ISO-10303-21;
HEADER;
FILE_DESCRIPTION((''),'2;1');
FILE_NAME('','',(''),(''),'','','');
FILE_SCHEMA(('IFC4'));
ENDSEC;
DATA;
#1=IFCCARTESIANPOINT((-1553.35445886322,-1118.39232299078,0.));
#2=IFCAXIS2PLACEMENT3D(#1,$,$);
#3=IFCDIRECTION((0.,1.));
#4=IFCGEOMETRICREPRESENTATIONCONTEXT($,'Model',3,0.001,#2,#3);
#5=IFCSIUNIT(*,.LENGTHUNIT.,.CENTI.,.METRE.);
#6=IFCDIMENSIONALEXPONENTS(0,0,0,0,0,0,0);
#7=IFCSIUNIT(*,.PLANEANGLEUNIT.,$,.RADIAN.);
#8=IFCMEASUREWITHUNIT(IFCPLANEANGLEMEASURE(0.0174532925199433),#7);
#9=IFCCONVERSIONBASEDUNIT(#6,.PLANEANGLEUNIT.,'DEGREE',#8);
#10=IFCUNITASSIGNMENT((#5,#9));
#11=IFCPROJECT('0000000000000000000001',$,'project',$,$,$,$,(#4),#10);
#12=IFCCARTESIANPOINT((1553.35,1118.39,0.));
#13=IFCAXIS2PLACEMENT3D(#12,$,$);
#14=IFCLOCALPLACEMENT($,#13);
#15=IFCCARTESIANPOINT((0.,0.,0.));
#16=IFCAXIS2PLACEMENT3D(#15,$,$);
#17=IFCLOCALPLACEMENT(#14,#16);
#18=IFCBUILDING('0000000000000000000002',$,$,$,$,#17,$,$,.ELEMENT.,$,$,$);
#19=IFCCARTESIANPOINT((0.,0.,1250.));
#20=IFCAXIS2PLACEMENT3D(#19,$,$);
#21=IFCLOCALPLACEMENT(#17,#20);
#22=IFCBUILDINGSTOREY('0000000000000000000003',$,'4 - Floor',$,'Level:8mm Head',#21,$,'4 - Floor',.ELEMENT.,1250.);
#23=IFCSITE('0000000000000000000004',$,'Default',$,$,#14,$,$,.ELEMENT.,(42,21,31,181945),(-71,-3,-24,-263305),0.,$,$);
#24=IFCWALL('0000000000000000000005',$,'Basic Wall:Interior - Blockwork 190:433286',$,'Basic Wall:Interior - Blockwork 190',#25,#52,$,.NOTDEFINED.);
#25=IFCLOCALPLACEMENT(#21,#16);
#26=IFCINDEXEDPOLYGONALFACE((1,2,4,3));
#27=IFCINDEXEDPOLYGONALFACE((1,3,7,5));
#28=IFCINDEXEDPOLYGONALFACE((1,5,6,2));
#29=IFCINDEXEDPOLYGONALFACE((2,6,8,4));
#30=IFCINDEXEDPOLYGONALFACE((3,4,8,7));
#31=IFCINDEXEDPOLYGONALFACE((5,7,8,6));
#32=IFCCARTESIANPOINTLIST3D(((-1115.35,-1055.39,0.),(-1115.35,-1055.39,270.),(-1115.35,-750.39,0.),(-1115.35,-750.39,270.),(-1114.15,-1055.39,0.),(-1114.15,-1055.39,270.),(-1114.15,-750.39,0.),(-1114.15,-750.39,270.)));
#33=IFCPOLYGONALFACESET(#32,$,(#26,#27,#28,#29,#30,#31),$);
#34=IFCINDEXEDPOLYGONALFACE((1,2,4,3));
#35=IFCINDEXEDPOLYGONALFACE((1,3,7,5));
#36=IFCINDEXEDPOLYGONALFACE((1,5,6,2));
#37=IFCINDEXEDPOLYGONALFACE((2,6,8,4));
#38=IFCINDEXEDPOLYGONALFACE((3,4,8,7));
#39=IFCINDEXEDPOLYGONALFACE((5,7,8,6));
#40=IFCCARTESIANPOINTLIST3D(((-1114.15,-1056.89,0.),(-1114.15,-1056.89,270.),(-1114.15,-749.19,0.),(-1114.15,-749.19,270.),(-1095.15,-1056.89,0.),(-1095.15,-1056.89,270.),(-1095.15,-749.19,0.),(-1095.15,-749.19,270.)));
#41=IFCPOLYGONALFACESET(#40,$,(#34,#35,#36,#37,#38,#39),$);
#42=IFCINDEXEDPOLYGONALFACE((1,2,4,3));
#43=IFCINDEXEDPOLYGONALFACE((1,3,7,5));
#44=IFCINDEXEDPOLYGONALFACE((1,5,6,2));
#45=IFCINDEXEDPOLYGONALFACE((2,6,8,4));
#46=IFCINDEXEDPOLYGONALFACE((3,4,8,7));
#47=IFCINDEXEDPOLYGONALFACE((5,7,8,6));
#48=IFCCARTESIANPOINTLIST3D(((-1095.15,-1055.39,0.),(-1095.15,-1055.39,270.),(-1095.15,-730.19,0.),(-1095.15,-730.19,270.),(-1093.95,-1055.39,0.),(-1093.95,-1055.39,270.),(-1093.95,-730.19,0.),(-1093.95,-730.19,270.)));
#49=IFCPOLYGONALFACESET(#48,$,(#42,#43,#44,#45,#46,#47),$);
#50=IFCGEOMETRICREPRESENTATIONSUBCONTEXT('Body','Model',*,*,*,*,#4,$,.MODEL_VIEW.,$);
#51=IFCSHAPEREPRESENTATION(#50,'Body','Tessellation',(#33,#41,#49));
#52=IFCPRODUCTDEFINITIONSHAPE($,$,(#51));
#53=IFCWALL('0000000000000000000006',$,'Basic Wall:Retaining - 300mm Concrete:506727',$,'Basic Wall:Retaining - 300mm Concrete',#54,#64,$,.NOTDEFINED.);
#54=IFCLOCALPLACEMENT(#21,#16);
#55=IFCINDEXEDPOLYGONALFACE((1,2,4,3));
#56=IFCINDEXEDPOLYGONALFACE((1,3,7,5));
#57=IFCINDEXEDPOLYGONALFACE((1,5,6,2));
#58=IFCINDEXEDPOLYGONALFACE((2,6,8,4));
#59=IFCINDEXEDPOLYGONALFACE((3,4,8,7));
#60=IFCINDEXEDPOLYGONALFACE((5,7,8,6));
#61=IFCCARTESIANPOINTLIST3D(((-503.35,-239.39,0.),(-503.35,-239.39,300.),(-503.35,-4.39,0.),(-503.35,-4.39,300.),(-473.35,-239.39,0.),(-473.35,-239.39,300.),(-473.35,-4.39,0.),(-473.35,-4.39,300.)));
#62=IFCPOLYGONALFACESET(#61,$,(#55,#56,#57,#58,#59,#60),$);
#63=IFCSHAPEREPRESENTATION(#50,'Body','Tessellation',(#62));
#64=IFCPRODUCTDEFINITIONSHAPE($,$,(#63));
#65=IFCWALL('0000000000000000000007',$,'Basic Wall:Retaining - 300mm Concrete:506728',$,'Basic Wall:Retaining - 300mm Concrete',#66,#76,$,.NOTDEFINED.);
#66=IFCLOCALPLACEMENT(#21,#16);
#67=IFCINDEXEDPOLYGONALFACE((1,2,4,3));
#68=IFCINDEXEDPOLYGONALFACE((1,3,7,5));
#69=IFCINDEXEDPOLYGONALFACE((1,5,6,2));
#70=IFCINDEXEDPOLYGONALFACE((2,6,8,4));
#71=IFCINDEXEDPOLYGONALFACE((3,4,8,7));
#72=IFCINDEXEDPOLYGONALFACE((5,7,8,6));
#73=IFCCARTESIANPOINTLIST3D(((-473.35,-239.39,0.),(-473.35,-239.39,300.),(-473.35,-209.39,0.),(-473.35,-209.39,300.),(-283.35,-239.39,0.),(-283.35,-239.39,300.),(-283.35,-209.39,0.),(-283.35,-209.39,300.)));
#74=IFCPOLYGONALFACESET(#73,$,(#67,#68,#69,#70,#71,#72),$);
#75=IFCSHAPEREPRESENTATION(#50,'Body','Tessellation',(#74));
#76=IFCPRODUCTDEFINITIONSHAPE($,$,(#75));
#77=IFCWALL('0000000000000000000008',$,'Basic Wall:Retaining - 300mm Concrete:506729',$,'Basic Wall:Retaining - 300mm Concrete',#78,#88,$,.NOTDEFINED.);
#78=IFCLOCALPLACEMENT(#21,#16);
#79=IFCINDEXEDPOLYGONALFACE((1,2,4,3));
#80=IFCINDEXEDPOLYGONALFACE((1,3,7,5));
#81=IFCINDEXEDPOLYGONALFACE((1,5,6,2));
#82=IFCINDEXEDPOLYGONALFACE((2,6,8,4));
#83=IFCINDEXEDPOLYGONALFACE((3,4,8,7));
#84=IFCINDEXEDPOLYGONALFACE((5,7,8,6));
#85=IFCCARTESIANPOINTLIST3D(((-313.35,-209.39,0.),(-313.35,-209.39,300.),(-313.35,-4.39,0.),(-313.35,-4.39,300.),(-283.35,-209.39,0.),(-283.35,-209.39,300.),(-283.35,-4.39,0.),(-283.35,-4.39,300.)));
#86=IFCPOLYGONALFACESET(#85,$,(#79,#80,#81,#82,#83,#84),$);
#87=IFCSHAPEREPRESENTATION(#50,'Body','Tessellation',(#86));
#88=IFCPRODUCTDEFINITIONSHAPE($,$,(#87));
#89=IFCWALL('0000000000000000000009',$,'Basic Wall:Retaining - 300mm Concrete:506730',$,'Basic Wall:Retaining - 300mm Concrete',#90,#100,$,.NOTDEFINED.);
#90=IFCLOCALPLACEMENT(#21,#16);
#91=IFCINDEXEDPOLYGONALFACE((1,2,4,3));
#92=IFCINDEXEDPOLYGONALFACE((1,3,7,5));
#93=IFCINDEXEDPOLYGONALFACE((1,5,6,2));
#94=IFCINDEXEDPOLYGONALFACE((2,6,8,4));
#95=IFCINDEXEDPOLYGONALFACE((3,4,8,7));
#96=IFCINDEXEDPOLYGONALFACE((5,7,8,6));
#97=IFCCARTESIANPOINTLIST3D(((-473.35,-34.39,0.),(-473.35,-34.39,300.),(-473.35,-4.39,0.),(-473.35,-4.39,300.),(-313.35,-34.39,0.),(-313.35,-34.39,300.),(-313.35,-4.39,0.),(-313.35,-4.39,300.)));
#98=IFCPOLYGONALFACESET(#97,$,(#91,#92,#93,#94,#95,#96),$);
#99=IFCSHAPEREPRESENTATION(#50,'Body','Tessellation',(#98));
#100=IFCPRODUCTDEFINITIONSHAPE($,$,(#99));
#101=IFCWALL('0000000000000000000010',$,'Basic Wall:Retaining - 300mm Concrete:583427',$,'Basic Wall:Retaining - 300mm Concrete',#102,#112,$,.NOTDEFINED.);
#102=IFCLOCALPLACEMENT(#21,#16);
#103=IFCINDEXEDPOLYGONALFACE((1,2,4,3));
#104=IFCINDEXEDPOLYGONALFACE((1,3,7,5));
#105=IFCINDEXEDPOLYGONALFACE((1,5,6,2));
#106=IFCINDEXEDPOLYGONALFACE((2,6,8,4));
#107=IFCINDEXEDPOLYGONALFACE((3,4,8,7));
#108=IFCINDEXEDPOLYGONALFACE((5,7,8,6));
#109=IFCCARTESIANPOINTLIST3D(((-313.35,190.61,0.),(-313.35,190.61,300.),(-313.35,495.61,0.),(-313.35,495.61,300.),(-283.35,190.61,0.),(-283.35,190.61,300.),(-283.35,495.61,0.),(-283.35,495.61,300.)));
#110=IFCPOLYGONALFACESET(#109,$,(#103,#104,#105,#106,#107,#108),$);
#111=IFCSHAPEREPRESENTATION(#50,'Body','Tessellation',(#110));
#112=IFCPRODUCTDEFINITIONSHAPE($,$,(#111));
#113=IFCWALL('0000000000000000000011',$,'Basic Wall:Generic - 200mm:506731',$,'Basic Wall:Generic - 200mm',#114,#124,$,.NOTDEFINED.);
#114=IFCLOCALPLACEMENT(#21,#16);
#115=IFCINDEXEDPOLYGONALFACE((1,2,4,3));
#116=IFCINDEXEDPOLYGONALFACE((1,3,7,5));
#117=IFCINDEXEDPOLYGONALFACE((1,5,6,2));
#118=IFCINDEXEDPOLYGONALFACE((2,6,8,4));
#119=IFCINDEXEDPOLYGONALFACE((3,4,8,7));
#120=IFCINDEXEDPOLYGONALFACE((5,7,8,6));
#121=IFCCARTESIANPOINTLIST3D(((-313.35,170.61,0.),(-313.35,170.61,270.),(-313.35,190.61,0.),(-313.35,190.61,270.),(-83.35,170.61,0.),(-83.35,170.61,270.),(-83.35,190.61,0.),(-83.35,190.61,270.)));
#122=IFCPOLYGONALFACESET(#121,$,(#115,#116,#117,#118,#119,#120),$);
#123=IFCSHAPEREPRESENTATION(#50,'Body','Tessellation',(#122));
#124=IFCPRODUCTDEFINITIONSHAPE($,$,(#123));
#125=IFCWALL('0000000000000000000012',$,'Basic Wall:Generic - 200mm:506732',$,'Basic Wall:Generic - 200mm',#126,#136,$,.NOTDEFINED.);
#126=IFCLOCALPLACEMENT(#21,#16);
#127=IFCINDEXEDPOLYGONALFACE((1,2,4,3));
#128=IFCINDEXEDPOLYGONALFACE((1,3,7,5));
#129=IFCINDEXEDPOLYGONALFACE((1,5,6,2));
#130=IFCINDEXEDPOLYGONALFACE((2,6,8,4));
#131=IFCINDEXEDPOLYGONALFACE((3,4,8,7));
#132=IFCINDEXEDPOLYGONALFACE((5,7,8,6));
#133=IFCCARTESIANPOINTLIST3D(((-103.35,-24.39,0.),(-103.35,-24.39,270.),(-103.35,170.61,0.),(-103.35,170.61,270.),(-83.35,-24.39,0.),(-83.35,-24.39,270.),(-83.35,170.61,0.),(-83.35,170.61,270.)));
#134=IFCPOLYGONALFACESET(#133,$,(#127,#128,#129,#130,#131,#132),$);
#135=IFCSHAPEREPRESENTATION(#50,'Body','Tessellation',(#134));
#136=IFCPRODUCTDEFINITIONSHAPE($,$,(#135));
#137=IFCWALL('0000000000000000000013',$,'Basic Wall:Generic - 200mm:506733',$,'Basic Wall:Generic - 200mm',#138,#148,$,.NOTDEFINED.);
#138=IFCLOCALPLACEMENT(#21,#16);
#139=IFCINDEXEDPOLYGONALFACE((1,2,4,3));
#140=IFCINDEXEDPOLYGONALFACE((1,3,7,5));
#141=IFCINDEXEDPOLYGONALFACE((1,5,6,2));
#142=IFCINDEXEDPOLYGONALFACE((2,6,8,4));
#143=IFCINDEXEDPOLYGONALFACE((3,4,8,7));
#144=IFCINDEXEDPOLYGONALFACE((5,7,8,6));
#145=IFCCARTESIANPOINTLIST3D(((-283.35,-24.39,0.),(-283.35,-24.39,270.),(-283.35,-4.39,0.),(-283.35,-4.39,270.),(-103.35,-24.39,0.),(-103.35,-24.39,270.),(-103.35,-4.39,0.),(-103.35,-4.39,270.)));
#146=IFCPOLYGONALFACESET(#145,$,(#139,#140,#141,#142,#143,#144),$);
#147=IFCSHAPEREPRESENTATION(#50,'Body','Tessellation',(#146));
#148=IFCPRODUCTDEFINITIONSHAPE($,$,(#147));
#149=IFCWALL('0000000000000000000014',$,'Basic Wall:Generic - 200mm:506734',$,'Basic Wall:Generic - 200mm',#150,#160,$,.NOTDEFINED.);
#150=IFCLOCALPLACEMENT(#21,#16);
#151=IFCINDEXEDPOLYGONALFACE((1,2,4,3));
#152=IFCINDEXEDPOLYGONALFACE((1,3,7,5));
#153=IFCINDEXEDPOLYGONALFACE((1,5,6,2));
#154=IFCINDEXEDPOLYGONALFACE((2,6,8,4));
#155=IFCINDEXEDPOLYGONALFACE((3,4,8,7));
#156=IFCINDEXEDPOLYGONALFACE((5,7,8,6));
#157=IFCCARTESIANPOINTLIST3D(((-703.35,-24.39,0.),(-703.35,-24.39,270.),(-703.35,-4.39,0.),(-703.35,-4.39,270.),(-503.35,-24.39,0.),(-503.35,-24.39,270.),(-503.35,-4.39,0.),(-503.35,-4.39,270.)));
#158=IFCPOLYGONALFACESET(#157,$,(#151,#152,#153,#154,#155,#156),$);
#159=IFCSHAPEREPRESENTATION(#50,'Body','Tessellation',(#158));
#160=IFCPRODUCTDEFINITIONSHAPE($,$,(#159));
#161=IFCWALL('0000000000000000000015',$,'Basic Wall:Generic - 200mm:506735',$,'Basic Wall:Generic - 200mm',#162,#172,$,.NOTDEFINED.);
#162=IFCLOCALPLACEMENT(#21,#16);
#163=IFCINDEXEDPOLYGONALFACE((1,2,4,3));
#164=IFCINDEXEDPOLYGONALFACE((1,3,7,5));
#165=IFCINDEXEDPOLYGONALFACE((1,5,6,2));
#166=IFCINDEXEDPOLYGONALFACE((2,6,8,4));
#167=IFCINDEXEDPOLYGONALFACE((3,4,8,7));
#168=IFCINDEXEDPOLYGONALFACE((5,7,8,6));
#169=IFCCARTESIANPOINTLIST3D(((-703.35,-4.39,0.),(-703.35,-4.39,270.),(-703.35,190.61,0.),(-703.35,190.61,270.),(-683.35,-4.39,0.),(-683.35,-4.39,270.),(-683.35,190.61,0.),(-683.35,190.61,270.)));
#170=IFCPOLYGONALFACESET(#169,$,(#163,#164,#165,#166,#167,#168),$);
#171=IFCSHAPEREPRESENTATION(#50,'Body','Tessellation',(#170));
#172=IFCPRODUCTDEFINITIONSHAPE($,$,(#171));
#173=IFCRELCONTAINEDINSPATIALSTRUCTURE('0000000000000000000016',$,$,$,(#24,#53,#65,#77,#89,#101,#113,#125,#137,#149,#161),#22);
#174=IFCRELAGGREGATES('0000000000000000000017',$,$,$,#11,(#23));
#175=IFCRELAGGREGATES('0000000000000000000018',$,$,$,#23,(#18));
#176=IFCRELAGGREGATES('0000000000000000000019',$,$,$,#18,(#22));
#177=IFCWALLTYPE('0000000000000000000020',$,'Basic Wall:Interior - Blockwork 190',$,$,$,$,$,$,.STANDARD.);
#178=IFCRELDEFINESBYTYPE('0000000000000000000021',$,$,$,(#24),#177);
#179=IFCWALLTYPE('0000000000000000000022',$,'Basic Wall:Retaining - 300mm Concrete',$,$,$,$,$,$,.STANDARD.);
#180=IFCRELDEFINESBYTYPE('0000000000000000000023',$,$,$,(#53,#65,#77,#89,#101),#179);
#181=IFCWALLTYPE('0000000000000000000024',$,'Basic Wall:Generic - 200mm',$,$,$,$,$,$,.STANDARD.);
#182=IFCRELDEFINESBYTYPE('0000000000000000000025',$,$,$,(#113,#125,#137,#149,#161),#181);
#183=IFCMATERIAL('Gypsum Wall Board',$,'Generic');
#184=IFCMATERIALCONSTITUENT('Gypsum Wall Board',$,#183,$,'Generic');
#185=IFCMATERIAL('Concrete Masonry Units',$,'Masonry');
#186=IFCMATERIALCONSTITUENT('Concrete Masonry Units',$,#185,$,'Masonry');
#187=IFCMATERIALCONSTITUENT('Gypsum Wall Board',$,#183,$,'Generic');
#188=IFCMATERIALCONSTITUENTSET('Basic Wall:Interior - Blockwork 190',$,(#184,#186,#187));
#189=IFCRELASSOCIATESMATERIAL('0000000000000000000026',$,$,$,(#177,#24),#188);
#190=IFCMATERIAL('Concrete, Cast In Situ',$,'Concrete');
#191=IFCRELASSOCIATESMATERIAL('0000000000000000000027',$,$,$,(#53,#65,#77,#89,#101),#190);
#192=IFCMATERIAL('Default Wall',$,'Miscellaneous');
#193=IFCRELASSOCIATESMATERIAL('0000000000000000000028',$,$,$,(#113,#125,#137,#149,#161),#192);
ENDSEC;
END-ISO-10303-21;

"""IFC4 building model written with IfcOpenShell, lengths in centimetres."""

from ifc_helpers import new_model, entity, si_unit, converted_unit, direction, frame, origin, place, context, subcontext, project, spatial, indexed_curve, outline, extrude, material, constituent, constituent_set, type_object, element, save


model = new_model("IFC4")

# Units and contexts
model_context = context("Model", 3, precision=0.001, world=frame((-1553.35445886322, -1118.39232299078, 0.0)), true_north=direction((0.0, 1.0)))
body_context = subcontext(model_context, "Body", "Model", "MODEL_VIEW")
ifc_project = project(units=[si_unit("LENGTHUNIT", "METRE", prefix="CENTI"), converted_unit("PLANEANGLEUNIT", "DEGREE", entity("IfcPlaneAngleMeasure", 0.0174532925199433), si_unit("PLANEANGLEUNIT", "RADIAN"), dimensions=[0, 0, 0, 0, 0, 0, 0])], contexts=[model_context])

# Site, building, storey
site_placement = place(None, frame((1553.35, 1118.39, 0.0)))
site = spatial("IfcSite", under=ifc_project, at=site_placement, Name="Default", CompositionType="ELEMENT", RefLatitude=(42, 21, 31, 181945), RefLongitude=(-71, -3, -24, -263305), RefElevation=0.0)
building_placement = place(site_placement, origin())
building = spatial("IfcBuilding", under=site, at=building_placement, CompositionType="ELEMENT")
storey_placement = place(building_placement, frame((0.0, 0.0, 1250.0)))
storey = spatial("IfcBuildingStorey", under=building, at=storey_placement, Name="4 - Floor", ObjectType="Level:8mm Head", LongName="4 - Floor", CompositionType="ELEMENT", Elevation=1250.0)

# Shared definitions
ifc_material_1 = material(Name="Concrete Masonry Units", Category="Masonry")

# Shared definitions
ifc_material_2 = material(Name="Gypsum Wall Board", Category="Generic")
ifc_constituent_1 = constituent(ifc_material_2, Name="Gypsum Wall Board", Category="Generic")
ifc_constituent_2 = constituent(ifc_material_1, Name="Concrete Masonry Units", Category="Masonry")
ifc_constituent_3 = constituent(ifc_material_2, Name="Gypsum Wall Board", Category="Generic")
ifc_constituent_set_1 = constituent_set(constituents=[ifc_constituent_1, ifc_constituent_2, ifc_constituent_3], Name="Basic Wall:Interior - Blockwork 190")
wall_type_1 = type_object("IfcWallType", Name="Basic Wall:Interior - Blockwork 190", PredefinedType="STANDARD", material=ifc_constituent_set_1)

# Walls
wall_1_placement = place(storey_placement, frame((-1104.65, -750.39, 0.0), z_axis=(0.0, 0.0, 1.0), x_axis=(0.0, -1.0, 0.0)))
element("IfcWall", 1, at=wall_1_placement, inside=storey, type_object=wall_type_1, material=ifc_constituent_set_1, Name="Basic Wall:Interior - Blockwork 190:433286", ObjectType="Basic Wall:Interior - Blockwork 190", PredefinedType="NOTDEFINED", context=body_context, shape_type="SweptSolid", body=[
    extrude(outline(indexed_curve([(-0.6, -152.5), (0.6, -152.5), (0.6, 152.5), (-0.6, 152.5), (-0.6, -152.5)], self_intersect=False)), frame((152.5, -10.1, 0.0), z_axis=(0.0, 0.0, 1.0), x_axis=(0.0, 1.0, 0.0)), (0.0, 0.0, 1.0), 270.0),
    extrude(outline(indexed_curve([(-153.85, -9.5), (153.85, -9.5), (153.85, 9.5), (-153.85, 9.5), (-153.85, -9.5)], self_intersect=False)), frame((152.65, 0.0, 0.0)), (0.0, 0.0, 1.0), 270.0),
    extrude(outline(indexed_curve([(-0.6, -162.6), (0.6, -162.6), (0.6, 162.6), (-0.6, 162.6), (-0.6, -162.6)], self_intersect=False)), frame((142.4, 10.1, 0.0), z_axis=(0.0, 0.0, 1.0), x_axis=(0.0, -1.0, 0.0)), (0.0, 0.0, 1.0), 270.0),
])
ifc_material_3 = material(Name="Concrete, Cast In Situ", Category="Concrete")
wall_type_2 = type_object("IfcWallType", Name="Basic Wall:Retaining - 300mm Concrete", PredefinedType="STANDARD")
wall_2_placement = place(storey_placement, frame((-488.35, -4.39, 0.0), z_axis=(0.0, 0.0, 1.0), x_axis=(0.0, -1.0, 0.0)))
element("IfcWall", 2, at=wall_2_placement, inside=storey, type_object=wall_type_2, material=ifc_material_3, Name="Basic Wall:Retaining - 300mm Concrete:506727", ObjectType="Basic Wall:Retaining - 300mm Concrete", PredefinedType="NOTDEFINED", context=body_context, shape_type="SweptSolid", body=[
    extrude(outline(indexed_curve([(235.0, 15.0), (0.0, 15.0), (0.0, -15.0), (235.0, -15.0), (235.0, 15.0)], self_intersect=False)), origin(), (0.0, 0.0, 1.0), 300.0),
])
wall_3_placement = place(storey_placement, frame((-473.35, -224.39, 0.0)))
element("IfcWall", 3, at=wall_3_placement, inside=storey, type_object=wall_type_2, material=ifc_material_3, Name="Basic Wall:Retaining - 300mm Concrete:506728", ObjectType="Basic Wall:Retaining - 300mm Concrete", PredefinedType="NOTDEFINED", context=body_context, shape_type="SweptSolid", body=[
    extrude(outline(indexed_curve([(190.0, 15.0), (0.0, 15.0), (0.0, -15.0), (190.0, -15.0), (190.0, 15.0)], self_intersect=False)), origin(), (0.0, 0.0, 1.0), 300.0),
])
wall_4_placement = place(storey_placement, frame((-298.35, -209.39, 0.0), z_axis=(0.0, 0.0, 1.0), x_axis=(0.0, 1.0, 0.0)))
element("IfcWall", 4, at=wall_4_placement, inside=storey, type_object=wall_type_2, material=ifc_material_3, Name="Basic Wall:Retaining - 300mm Concrete:506729", ObjectType="Basic Wall:Retaining - 300mm Concrete", PredefinedType="NOTDEFINED", context=body_context, shape_type="SweptSolid", body=[
    extrude(outline(indexed_curve([(205.0, 15.0), (0.0, 15.0), (0.0, -15.0), (205.0, -15.0), (205.0, 15.0)], self_intersect=False)), origin(), (0.0, 0.0, 1.0), 300.0),
])
wall_5_placement = place(storey_placement, frame((-313.35, -19.39, 0.0), z_axis=(0.0, 0.0, 1.0), x_axis=(-1.0, 0.0, 0.0)))
element("IfcWall", 5, at=wall_5_placement, inside=storey, type_object=wall_type_2, material=ifc_material_3, Name="Basic Wall:Retaining - 300mm Concrete:506730", ObjectType="Basic Wall:Retaining - 300mm Concrete", PredefinedType="NOTDEFINED", context=body_context, shape_type="SweptSolid", body=[
    extrude(outline(indexed_curve([(160.0, 15.0), (0.0, 15.0), (0.0, -15.0), (160.0, -15.0), (160.0, 15.0)], self_intersect=False)), origin(), (0.0, 0.0, 1.0), 300.0),
])
wall_6_placement = place(storey_placement, frame((-298.35, 495.61, 0.0), z_axis=(0.0, 0.0, 1.0), x_axis=(0.0, -1.0, 0.0)))
element("IfcWall", 6, at=wall_6_placement, inside=storey, type_object=wall_type_2, material=ifc_material_3, Name="Basic Wall:Retaining - 300mm Concrete:583427", ObjectType="Basic Wall:Retaining - 300mm Concrete", PredefinedType="NOTDEFINED", context=body_context, shape_type="SweptSolid", body=[
    extrude(outline(indexed_curve([(305.0, 15.0), (0.0, 15.0), (0.0, -15.0), (305.0, -15.0), (305.0, 15.0)], self_intersect=False)), origin(), (0.0, 0.0, 1.0), 300.0),
])
ifc_material_4 = material(Name="Default Wall", Category="Miscellaneous")
wall_type_3 = type_object("IfcWallType", Name="Basic Wall:Generic - 200mm", PredefinedType="STANDARD")
wall_7_placement = place(storey_placement, frame((-313.35, 180.61, 0.0)))
element("IfcWall", 7, at=wall_7_placement, inside=storey, type_object=wall_type_3, material=ifc_material_4, Name="Basic Wall:Generic - 200mm:506731", ObjectType="Basic Wall:Generic - 200mm", PredefinedType="NOTDEFINED", context=body_context, shape_type="SweptSolid", body=[
    extrude(outline(indexed_curve([(230.0, 10.0), (0.0, 10.0), (0.0, -10.0), (230.0, -10.0), (230.0, 10.0)], self_intersect=False)), origin(), (0.0, 0.0, 1.0), 270.0),
])
wall_8_placement = place(storey_placement, frame((-93.35, 170.61, 0.0), z_axis=(0.0, 0.0, 1.0), x_axis=(0.0, -1.0, 0.0)))
element("IfcWall", 8, at=wall_8_placement, inside=storey, type_object=wall_type_3, material=ifc_material_4, Name="Basic Wall:Generic - 200mm:506732", ObjectType="Basic Wall:Generic - 200mm", PredefinedType="NOTDEFINED", context=body_context, shape_type="SweptSolid", body=[
    extrude(outline(indexed_curve([(195.0, 10.0), (0.0, 10.0), (0.0, -10.0), (195.0, -10.0), (195.0, 10.0)], self_intersect=False)), origin(), (0.0, 0.0, 1.0), 270.0),
])
wall_9_placement = place(storey_placement, frame((-283.35, -14.39, 0.0)))
element("IfcWall", 9, at=wall_9_placement, inside=storey, type_object=wall_type_3, material=ifc_material_4, Name="Basic Wall:Generic - 200mm:506733", ObjectType="Basic Wall:Generic - 200mm", PredefinedType="NOTDEFINED", context=body_context, shape_type="SweptSolid", body=[
    extrude(outline(indexed_curve([(180.0, 10.0), (0.0, 10.0), (0.0, -10.0), (180.0, -10.0), (180.0, 10.0)], self_intersect=False)), origin(), (0.0, 0.0, 1.0), 270.0),
])
wall_10_placement = place(storey_placement, frame((-503.35, -14.39, 0.0), z_axis=(0.0, 0.0, 1.0), x_axis=(-1.0, 0.0, 0.0)))
element("IfcWall", 10, at=wall_10_placement, inside=storey, type_object=wall_type_3, material=ifc_material_4, Name="Basic Wall:Generic - 200mm:506734", ObjectType="Basic Wall:Generic - 200mm", PredefinedType="NOTDEFINED", context=body_context, shape_type="SweptSolid", body=[
    extrude(outline(indexed_curve([(200.0, 10.0), (0.0, 10.0), (0.0, -10.0), (200.0, -10.0), (200.0, 10.0)], self_intersect=False)), origin(), (0.0, 0.0, 1.0), 270.0),
])
wall_11_placement = place(storey_placement, frame((-693.35, -4.39, 0.0), z_axis=(0.0, 0.0, 1.0), x_axis=(0.0, 1.0, 0.0)))
element("IfcWall", 11, at=wall_11_placement, inside=storey, type_object=wall_type_3, material=ifc_material_4, Name="Basic Wall:Generic - 200mm:506735", ObjectType="Basic Wall:Generic - 200mm", PredefinedType="NOTDEFINED", context=body_context, shape_type="SweptSolid", body=[
    extrude(outline(indexed_curve([(195.0, 10.0), (0.0, 10.0), (0.0, -10.0), (195.0, -10.0), (195.0, 10.0)], self_intersect=False)), origin(), (0.0, 0.0, 1.0), 270.0),
])

save(model, "model.ifc")
